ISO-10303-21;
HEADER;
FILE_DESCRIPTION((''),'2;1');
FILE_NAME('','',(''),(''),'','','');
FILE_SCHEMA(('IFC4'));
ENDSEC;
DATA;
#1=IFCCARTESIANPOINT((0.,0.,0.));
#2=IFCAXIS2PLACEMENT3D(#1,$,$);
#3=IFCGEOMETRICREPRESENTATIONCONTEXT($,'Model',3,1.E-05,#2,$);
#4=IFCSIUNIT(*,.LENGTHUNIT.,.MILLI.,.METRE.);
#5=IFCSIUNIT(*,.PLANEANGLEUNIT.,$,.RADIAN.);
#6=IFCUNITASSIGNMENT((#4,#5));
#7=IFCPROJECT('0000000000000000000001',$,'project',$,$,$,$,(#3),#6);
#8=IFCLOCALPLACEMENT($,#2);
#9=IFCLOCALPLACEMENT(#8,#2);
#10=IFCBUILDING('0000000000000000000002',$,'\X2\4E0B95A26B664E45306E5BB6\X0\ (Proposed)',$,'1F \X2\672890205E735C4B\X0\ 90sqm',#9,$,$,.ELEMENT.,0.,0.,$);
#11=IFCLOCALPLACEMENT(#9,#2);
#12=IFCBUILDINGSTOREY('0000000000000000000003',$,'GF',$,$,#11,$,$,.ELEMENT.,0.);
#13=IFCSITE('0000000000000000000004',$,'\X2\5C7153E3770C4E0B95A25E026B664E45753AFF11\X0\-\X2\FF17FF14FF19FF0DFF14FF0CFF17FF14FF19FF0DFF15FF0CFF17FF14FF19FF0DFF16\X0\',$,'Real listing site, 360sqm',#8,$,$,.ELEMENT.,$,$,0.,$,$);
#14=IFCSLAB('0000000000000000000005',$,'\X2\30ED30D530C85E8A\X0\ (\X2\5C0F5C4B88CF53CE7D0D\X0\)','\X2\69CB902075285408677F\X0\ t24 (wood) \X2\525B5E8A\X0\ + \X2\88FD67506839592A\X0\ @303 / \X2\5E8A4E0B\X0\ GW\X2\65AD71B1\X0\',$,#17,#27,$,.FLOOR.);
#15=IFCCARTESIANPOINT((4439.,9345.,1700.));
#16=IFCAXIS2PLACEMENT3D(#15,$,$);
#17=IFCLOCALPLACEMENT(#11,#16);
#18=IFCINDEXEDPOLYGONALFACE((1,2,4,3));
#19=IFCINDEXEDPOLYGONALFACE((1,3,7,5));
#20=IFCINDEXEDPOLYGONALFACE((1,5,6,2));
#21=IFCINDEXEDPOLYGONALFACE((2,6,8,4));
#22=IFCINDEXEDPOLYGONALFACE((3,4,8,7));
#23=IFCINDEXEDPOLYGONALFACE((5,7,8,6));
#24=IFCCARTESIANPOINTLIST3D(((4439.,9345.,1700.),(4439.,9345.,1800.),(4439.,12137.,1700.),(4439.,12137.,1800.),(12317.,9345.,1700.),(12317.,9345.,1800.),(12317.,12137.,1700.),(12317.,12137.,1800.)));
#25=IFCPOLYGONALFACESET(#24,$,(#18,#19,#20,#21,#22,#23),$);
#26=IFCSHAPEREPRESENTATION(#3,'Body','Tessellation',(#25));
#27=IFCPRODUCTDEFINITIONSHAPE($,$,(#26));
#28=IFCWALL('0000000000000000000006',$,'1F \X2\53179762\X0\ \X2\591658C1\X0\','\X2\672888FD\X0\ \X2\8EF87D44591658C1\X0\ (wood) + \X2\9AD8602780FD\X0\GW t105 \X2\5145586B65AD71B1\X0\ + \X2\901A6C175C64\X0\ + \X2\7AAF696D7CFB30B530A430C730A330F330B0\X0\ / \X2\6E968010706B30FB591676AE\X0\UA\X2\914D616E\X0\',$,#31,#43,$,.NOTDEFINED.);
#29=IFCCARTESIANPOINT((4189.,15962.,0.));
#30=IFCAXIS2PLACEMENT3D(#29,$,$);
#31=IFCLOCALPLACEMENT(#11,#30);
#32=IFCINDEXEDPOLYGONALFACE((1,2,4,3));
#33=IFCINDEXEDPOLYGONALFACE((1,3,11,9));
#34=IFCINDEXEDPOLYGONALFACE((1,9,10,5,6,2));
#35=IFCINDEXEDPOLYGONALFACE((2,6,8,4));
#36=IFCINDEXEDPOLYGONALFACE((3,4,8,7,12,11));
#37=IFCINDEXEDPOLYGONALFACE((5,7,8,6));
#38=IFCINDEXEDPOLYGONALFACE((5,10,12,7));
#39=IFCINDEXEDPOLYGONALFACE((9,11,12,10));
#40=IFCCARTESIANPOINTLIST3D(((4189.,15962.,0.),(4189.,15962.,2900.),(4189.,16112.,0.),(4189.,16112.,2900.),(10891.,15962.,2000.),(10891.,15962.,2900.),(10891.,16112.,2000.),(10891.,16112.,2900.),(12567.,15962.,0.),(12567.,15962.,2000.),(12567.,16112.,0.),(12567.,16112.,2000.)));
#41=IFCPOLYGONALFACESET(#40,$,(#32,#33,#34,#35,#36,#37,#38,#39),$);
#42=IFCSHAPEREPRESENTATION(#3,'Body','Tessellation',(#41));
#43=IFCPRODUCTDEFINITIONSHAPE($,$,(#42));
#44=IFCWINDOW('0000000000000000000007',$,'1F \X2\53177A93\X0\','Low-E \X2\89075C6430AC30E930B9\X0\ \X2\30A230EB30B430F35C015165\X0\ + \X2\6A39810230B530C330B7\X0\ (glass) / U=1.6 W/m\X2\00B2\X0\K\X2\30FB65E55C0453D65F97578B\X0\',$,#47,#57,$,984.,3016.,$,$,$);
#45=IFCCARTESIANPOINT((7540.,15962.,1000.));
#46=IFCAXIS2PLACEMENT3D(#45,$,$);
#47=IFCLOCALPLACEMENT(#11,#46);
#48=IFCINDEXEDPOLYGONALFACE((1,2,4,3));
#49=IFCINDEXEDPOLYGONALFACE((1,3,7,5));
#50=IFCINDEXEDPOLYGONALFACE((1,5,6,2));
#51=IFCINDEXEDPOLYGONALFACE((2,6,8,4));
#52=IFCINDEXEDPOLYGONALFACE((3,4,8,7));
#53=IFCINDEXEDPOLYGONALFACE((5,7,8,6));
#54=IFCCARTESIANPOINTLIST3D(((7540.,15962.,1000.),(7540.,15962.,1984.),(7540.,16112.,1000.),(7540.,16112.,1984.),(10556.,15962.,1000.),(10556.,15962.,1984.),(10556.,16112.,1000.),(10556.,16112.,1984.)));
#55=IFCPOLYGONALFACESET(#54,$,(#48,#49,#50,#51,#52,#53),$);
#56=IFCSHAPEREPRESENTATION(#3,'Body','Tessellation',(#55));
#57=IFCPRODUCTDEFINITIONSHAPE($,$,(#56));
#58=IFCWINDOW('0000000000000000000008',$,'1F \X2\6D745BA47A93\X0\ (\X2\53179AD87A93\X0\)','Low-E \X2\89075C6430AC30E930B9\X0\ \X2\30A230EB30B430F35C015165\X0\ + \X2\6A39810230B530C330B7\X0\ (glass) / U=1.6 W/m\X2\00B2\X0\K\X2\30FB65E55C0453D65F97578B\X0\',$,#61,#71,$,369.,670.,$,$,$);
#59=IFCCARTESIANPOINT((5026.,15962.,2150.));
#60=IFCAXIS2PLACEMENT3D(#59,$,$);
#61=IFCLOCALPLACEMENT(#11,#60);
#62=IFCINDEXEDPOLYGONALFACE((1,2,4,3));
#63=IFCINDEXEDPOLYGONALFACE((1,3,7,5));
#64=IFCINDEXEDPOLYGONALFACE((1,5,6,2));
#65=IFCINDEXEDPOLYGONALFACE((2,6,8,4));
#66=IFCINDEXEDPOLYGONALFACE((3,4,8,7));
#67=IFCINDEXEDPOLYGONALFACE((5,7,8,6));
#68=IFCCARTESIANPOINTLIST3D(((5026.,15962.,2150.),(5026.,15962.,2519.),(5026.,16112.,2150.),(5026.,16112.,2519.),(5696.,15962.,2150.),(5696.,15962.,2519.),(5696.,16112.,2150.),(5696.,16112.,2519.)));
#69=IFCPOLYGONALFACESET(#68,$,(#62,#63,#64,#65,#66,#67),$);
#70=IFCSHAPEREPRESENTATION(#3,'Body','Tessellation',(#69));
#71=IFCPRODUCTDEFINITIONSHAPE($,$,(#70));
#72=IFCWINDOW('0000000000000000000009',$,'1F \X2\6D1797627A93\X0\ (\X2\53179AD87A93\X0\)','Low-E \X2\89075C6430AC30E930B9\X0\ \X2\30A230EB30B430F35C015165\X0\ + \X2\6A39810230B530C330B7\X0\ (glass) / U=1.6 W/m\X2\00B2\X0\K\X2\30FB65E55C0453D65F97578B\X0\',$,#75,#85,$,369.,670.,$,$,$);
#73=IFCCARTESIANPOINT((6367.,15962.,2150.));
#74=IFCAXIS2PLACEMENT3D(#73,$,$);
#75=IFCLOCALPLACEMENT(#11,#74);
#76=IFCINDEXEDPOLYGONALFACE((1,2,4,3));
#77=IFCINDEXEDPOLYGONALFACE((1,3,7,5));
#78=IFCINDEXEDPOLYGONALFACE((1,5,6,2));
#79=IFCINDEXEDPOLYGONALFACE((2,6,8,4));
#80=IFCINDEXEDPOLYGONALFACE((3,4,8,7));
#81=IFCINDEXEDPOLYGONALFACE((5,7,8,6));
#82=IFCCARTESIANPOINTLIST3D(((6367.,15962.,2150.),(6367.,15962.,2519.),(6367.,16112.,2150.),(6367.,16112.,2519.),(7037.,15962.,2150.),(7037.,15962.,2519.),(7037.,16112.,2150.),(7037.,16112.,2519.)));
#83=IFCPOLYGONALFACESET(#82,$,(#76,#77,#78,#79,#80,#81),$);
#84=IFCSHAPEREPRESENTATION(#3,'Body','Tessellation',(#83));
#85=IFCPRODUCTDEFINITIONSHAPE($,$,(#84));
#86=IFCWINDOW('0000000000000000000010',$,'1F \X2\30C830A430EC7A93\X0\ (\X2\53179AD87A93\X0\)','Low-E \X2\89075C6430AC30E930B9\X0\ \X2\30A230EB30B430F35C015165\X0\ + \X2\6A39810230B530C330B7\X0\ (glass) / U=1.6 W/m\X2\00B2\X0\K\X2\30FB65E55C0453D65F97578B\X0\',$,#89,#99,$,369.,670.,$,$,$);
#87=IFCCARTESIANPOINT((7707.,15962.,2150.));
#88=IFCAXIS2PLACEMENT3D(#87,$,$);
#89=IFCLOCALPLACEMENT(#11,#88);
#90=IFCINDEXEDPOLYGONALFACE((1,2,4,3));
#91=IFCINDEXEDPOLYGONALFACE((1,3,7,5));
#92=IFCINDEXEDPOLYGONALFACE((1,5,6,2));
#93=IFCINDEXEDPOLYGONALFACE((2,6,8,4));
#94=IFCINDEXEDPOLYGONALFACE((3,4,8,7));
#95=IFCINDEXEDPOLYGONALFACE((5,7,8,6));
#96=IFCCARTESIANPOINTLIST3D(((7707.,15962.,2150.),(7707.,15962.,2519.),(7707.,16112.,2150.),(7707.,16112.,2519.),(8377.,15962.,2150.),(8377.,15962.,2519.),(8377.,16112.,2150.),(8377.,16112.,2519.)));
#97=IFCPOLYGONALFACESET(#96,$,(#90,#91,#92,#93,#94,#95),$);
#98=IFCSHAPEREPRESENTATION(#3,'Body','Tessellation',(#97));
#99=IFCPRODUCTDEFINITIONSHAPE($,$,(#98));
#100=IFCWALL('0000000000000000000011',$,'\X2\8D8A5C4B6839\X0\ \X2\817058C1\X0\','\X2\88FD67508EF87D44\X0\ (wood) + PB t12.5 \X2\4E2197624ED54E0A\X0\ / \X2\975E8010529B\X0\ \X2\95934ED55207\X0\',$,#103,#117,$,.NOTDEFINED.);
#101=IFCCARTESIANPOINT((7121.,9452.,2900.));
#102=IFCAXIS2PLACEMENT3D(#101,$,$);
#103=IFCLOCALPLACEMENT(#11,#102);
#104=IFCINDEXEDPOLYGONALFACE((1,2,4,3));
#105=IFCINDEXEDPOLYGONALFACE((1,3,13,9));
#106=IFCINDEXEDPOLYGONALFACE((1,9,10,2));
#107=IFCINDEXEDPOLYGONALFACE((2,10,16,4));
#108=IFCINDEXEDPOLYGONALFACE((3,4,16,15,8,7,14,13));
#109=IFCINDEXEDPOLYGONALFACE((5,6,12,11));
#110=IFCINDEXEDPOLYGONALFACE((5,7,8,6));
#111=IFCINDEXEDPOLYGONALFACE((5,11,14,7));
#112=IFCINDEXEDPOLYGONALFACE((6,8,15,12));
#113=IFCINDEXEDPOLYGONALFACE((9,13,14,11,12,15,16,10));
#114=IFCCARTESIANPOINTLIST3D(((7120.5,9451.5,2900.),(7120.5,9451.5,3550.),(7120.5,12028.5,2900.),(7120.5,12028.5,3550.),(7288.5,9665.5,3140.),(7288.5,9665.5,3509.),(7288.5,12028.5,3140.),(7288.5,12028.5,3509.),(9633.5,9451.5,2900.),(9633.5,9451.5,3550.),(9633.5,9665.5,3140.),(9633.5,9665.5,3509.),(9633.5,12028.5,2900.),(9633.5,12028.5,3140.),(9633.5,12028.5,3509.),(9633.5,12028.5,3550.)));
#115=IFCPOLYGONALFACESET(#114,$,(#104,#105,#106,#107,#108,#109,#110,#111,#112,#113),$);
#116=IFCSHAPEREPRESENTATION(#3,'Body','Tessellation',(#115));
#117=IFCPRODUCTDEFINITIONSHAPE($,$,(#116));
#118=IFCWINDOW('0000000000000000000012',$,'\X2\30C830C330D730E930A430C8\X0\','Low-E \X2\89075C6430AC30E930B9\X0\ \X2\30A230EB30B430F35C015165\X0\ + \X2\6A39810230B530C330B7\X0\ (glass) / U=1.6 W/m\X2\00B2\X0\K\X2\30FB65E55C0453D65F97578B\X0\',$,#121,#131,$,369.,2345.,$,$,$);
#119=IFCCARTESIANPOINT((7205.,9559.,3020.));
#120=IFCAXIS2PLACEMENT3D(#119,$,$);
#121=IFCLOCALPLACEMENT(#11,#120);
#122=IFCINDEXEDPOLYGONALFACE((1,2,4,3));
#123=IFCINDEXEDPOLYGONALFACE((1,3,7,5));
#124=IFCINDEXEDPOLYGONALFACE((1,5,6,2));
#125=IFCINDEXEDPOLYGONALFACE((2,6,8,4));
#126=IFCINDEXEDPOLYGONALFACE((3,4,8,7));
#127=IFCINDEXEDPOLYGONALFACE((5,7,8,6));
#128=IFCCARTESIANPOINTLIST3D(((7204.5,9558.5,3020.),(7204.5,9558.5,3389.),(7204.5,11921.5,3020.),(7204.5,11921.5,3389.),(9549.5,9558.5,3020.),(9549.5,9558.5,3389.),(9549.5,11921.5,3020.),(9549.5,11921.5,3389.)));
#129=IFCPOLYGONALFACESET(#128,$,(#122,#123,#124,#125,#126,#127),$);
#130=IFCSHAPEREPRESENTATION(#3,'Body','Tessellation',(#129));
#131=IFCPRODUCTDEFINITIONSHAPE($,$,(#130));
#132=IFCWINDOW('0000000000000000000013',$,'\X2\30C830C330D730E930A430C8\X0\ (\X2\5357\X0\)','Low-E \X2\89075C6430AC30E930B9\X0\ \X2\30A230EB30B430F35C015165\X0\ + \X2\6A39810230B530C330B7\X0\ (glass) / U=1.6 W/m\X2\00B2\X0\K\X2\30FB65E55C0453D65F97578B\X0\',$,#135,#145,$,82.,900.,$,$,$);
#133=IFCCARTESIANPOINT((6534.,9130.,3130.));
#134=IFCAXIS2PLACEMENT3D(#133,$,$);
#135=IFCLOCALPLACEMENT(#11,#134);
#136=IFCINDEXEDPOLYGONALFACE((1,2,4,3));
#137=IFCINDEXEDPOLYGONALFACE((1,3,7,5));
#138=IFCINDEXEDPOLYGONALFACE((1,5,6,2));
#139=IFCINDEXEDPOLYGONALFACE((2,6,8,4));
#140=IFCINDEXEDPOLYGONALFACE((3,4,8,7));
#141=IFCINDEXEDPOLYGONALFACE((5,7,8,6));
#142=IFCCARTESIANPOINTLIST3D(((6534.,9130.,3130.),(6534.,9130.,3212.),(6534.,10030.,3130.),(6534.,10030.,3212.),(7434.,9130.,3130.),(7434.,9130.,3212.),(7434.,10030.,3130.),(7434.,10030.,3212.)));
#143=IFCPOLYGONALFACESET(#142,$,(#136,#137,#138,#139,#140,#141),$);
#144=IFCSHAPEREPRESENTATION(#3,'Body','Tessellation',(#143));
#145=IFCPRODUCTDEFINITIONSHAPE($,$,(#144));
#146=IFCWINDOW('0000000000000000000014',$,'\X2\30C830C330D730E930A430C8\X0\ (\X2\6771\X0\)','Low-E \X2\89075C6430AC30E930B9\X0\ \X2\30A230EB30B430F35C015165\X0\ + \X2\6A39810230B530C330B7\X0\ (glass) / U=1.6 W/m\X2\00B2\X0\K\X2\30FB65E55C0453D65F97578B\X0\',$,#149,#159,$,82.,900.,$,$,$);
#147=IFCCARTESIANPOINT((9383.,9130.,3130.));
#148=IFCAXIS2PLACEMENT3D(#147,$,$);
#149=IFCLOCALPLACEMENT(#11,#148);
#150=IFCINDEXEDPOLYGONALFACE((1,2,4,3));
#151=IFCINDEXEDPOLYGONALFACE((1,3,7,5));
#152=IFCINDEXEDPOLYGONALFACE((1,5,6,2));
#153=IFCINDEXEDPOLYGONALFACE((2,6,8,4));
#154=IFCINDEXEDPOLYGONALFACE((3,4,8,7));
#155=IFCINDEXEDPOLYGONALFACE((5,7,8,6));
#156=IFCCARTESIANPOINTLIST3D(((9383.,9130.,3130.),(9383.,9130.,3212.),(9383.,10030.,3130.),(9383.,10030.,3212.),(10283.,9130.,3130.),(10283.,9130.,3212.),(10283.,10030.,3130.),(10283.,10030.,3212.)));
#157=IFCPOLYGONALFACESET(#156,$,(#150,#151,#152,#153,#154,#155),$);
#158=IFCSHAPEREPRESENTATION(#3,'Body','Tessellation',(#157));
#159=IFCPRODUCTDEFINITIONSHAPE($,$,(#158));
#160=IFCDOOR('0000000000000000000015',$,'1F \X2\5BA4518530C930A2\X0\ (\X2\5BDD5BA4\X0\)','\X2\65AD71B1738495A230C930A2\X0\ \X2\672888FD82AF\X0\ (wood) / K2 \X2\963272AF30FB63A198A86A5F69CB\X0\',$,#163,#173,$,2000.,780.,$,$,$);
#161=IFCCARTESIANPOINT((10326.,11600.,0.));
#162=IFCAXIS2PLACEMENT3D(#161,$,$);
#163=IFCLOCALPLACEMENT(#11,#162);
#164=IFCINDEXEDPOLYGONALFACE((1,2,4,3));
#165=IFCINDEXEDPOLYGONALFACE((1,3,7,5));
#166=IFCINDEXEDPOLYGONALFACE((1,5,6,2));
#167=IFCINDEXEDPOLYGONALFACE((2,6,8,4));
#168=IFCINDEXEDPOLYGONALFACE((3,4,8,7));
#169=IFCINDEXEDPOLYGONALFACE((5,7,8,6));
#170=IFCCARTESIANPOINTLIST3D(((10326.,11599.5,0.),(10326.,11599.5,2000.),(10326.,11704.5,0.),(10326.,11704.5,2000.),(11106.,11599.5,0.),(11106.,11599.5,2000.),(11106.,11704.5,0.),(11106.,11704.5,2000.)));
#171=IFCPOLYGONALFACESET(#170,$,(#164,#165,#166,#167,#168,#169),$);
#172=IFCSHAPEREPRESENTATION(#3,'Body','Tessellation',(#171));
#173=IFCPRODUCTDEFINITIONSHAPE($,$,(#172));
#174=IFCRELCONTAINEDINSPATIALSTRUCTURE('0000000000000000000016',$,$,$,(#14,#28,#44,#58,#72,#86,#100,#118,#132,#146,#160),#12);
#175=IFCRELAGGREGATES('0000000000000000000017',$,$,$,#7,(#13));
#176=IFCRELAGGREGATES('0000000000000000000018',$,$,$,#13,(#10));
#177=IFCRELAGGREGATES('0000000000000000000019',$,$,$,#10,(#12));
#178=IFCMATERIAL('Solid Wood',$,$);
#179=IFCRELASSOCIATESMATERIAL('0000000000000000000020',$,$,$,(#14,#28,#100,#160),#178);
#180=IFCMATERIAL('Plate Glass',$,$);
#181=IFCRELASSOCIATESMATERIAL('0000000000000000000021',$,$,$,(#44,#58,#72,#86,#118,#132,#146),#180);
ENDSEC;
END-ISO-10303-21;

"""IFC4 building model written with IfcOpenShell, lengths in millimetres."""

from ifc_helpers import new_model, si_unit, frame, frame_2d, origin, place, context, project, spatial, rectangle, extrude, material, element, fill, save


model = new_model("IFC4")

# Units and contexts
model_context = context("Model", 3, precision=1e-05, world=origin())
ifc_project = project(units=[si_unit("LENGTHUNIT", "METRE", prefix="MILLI"), si_unit("PLANEANGLEUNIT", "RADIAN")], contexts=[model_context])

# Site, building, storey
site_placement = place(None, origin())
site = spatial("IfcSite", under=ifc_project, at=site_placement, Name="山口県下関市武久町１-７４９－４，７４９－５，７４９－６", ObjectType="Real listing site, 360sqm", CompositionType="ELEMENT", RefElevation=0.0)
building_placement = place(site_placement, origin())
building = spatial("IfcBuilding", under=site, at=building_placement, Name="下関武久の家 (Proposed)", ObjectType="1F 木造平屋 90sqm", CompositionType="ELEMENT", ElevationOfRefHeight=0.0, ElevationOfTerrain=0.0)
storey_placement = place(building_placement, origin())
storey = spatial("IfcBuildingStorey", under=building, at=storey_placement, Name="GF", CompositionType="ELEMENT", Elevation=0.0)

# Slab
ifc_material_1 = material(Name="Solid Wood")
slab_placement = place(storey_placement, frame((4439.0, 9345.0, 1700.0)))
element("IfcSlab", 1, at=slab_placement, inside=storey, material=ifc_material_1, Name="ロフト床 (小屋裏収納)", Description="構造用合板 t24 (wood) 剛床 + 製材根太 @303 / 床下 GW断熱", PredefinedType="FLOOR", context=model_context, shape_type="SweptSolid", body=[
    extrude(rectangle(XDim=7878.0, YDim=2792.0, at=frame_2d((3939.0, 1396.0))), frame((4439.0, 9345.0, 1700.0)), (0.0, 0.0, 1.0), 100.0),
])

# Wall, openings, windows
wall_1_placement = place(storey_placement, frame((4189.0, 15962.0, 0.0)))
wall_1 = element("IfcWall", 2, at=wall_1_placement, inside=storey, material=ifc_material_1, Name="1F 北面 外壁", Description="木製 軸組外壁 (wood) + 高性能GW t105 充填断熱 + 通気層 + 窯業系サイディング / 準耐火・外皮UA配慮", PredefinedType="NOTDEFINED", context=model_context, shape_type="SweptSolid", body=[
    extrude(rectangle(XDim=8378.0, YDim=150.0, at=frame_2d((4189.0, 75.0))), frame((4189.0, 15962.0, 0.0)), (0.0, 0.0, 1.0), 2900.0),
])
opening_1_placement = place(storey_placement, frame((7540.0, 15962.0, 1000.0)))
opening_1 = element("IfcOpeningElement", 3, at=opening_1_placement, cuts=wall_1, PredefinedType="NOTDEFINED", context=model_context, shape_type="SweptSolid", body=[
    extrude(rectangle(XDim=3016.0, YDim=150.0, at=frame_2d((1508.0, 75.0))), frame((7540.0, 15962.0, 1000.0)), (0.0, 0.0, 1.0), 984.0),
])
opening_2_placement = place(storey_placement, frame((5026.0, 15962.0, 2150.0)))
opening_2 = element("IfcOpeningElement", 4, at=opening_2_placement, cuts=wall_1, PredefinedType="NOTDEFINED", context=model_context, shape_type="SweptSolid", body=[
    extrude(rectangle(XDim=670.0, YDim=150.0, at=frame_2d((335.0, 75.0))), frame((5026.0, 15962.0, 2150.0)), (0.0, 0.0, 1.0), 369.0),
])
opening_3_placement = place(storey_placement, frame((6367.0, 15962.0, 2150.0)))
opening_3 = element("IfcOpeningElement", 5, at=opening_3_placement, cuts=wall_1, PredefinedType="NOTDEFINED", context=model_context, shape_type="SweptSolid", body=[
    extrude(rectangle(XDim=670.0, YDim=150.0, at=frame_2d((335.0, 75.0))), frame((6367.0, 15962.0, 2150.0)), (0.0, 0.0, 1.0), 369.0),
])
opening_4_placement = place(storey_placement, frame((7707.0, 15962.0, 2150.0)))
opening_4 = element("IfcOpeningElement", 6, at=opening_4_placement, cuts=wall_1, PredefinedType="NOTDEFINED", context=model_context, shape_type="SweptSolid", body=[
    extrude(rectangle(XDim=670.0, YDim=150.0, at=frame_2d((335.0, 75.0))), frame((7707.0, 15962.0, 2150.0)), (0.0, 0.0, 1.0), 369.0),
])
ifc_material_2 = material(Name="Plate Glass")
window_1_placement = place(storey_placement, frame((7540.0, 15962.0, 1000.0)))
window_1 = element("IfcWindow", 7, at=window_1_placement, inside=storey, material=ifc_material_2, Name="1F 北窓", Description="Low-E 複層ガラス アルゴン封入 + 樹脂サッシ (glass) / U=1.6 W/m²K・日射取得型", OverallHeight=984.0, OverallWidth=3016.0, context=model_context, shape_type="SweptSolid", body=[
    extrude(rectangle(XDim=3016.0, YDim=150.0, at=frame_2d((1508.0, 75.0))), frame((7540.0, 15962.0, 1000.0)), (0.0, 0.0, 1.0), 984.0),
])
fill(opening_1, window_1)
window_2_placement = place(storey_placement, frame((5026.0, 15962.0, 2150.0)))
window_2 = element("IfcWindow", 8, at=window_2_placement, inside=storey, material=ifc_material_2, Name="1F 浴室窓 (北高窓)", Description="Low-E 複層ガラス アルゴン封入 + 樹脂サッシ (glass) / U=1.6 W/m²K・日射取得型", OverallHeight=369.0, OverallWidth=670.0, context=model_context, shape_type="SweptSolid", body=[
    extrude(rectangle(XDim=670.0, YDim=150.0, at=frame_2d((335.0, 75.0))), frame((5026.0, 15962.0, 2150.0)), (0.0, 0.0, 1.0), 369.0),
])
fill(opening_2, window_2)
window_3_placement = place(storey_placement, frame((6367.0, 15962.0, 2150.0)))
window_3 = element("IfcWindow", 9, at=window_3_placement, inside=storey, material=ifc_material_2, Name="1F 洗面窓 (北高窓)", Description="Low-E 複層ガラス アルゴン封入 + 樹脂サッシ (glass) / U=1.6 W/m²K・日射取得型", OverallHeight=369.0, OverallWidth=670.0, context=model_context, shape_type="SweptSolid", body=[
    extrude(rectangle(XDim=670.0, YDim=150.0, at=frame_2d((335.0, 75.0))), frame((6367.0, 15962.0, 2150.0)), (0.0, 0.0, 1.0), 369.0),
])
fill(opening_3, window_3)
window_4_placement = place(storey_placement, frame((7707.0, 15962.0, 2150.0)))
window_4 = element("IfcWindow", 10, at=window_4_placement, inside=storey, material=ifc_material_2, Name="1F トイレ窓 (北高窓)", Description="Low-E 複層ガラス アルゴン封入 + 樹脂サッシ (glass) / U=1.6 W/m²K・日射取得型", OverallHeight=369.0, OverallWidth=670.0, context=model_context, shape_type="SweptSolid", body=[
    extrude(rectangle(XDim=670.0, YDim=150.0, at=frame_2d((335.0, 75.0))), frame((7707.0, 15962.0, 2150.0)), (0.0, 0.0, 1.0), 369.0),
])
fill(opening_4, window_4)

# Wall, openings, windows
wall_2_placement = place(storey_placement, frame((7121.0, 9452.0, 2900.0)))
wall_2 = element("IfcWall", 11, at=wall_2_placement, inside=storey, material=ifc_material_1, Name="越屋根 腰壁", Description="製材軸組 (wood) + PB t12.5 両面仕上 / 非耐力 間仕切", PredefinedType="NOTDEFINED", context=model_context, shape_type="SweptSolid", body=[
    extrude(rectangle(XDim=2513.0, YDim=2577.0, at=frame_2d((1256.0, 1288.0))), frame((7121.0, 9452.0, 2900.0)), (0.0, 0.0, 1.0), 650.0),
])
opening_5_placement = place(storey_placement, frame((7205.0, 9559.0, 3020.0)))
opening_5 = element("IfcOpeningElement", 12, at=opening_5_placement, cuts=wall_2, PredefinedType="NOTDEFINED", context=model_context, shape_type="SweptSolid", body=[
    extrude(rectangle(XDim=2345.0, YDim=2363.0, at=frame_2d((1172.0, 1181.0))), frame((7205.0, 9559.0, 3020.0)), (0.0, 0.0, 1.0), 369.0),
])
opening_6_placement = place(storey_placement, frame((6534.0, 9130.0, 3130.0)))
opening_6 = element("IfcOpeningElement", 13, at=opening_6_placement, cuts=wall_2, PredefinedType="NOTDEFINED", context=model_context, shape_type="SweptSolid", body=[
    extrude(rectangle(XDim=900.0, YDim=900.0, at=frame_2d((450.0, 450.0))), frame((6534.0, 9130.0, 3130.0)), (0.0, 0.0, 1.0), 82.0),
])
opening_7_placement = place(storey_placement, frame((9383.0, 9130.0, 3130.0)))
opening_7 = element("IfcOpeningElement", 14, at=opening_7_placement, cuts=wall_2, PredefinedType="NOTDEFINED", context=model_context, shape_type="SweptSolid", body=[
    extrude(rectangle(XDim=900.0, YDim=900.0, at=frame_2d((450.0, 450.0))), frame((9383.0, 9130.0, 3130.0)), (0.0, 0.0, 1.0), 82.0),
])
window_5_placement = place(storey_placement, frame((7205.0, 9559.0, 3020.0)))
window_5 = element("IfcWindow", 15, at=window_5_placement, inside=storey, material=ifc_material_2, Name="トップライト", Description="Low-E 複層ガラス アルゴン封入 + 樹脂サッシ (glass) / U=1.6 W/m²K・日射取得型", OverallHeight=369.0, OverallWidth=2345.0, context=model_context, shape_type="SweptSolid", body=[
    extrude(rectangle(XDim=2345.0, YDim=2363.0, at=frame_2d((1172.0, 1181.0))), frame((7205.0, 9559.0, 3020.0)), (0.0, 0.0, 1.0), 369.0),
])
fill(opening_5, window_5)
window_6_placement = place(storey_placement, frame((6534.0, 9130.0, 3130.0)))
window_6 = element("IfcWindow", 16, at=window_6_placement, inside=storey, material=ifc_material_2, Name="トップライト (南)", Description="Low-E 複層ガラス アルゴン封入 + 樹脂サッシ (glass) / U=1.6 W/m²K・日射取得型", OverallHeight=82.0, OverallWidth=900.0, context=model_context, shape_type="SweptSolid", body=[
    extrude(rectangle(XDim=900.0, YDim=900.0, at=frame_2d((450.0, 450.0))), frame((6534.0, 9130.0, 3130.0)), (0.0, 0.0, 1.0), 82.0),
])
fill(opening_6, window_6)
window_7_placement = place(storey_placement, frame((9383.0, 9130.0, 3130.0)))
window_7 = element("IfcWindow", 17, at=window_7_placement, inside=storey, material=ifc_material_2, Name="トップライト (東)", Description="Low-E 複層ガラス アルゴン封入 + 樹脂サッシ (glass) / U=1.6 W/m²K・日射取得型", OverallHeight=82.0, OverallWidth=900.0, context=model_context, shape_type="SweptSolid", body=[
    extrude(rectangle(XDim=900.0, YDim=900.0, at=frame_2d((450.0, 450.0))), frame((9383.0, 9130.0, 3130.0)), (0.0, 0.0, 1.0), 82.0),
])
fill(opening_7, window_7)

# Door
door_1_placement = place(storey_placement, frame((10326.0, 11600.0, 0.0)))
element("IfcDoor", 18, at=door_1_placement, inside=storey, material=ifc_material_1, Name="1F 室内ドア (寝室)", Description="断熱玄関ドア 木製芯 (wood) / K2 防犯・採風機構", OverallHeight=2000.0, OverallWidth=780.0, context=model_context, shape_type="SweptSolid", body=[
    extrude(rectangle(XDim=780.0, YDim=105.0, at=frame_2d((390.0, 52.0))), frame((10326.0, 11600.0, 0.0)), (0.0, 0.0, 1.0), 2000.0),
])

save(model, "model.ifc")
